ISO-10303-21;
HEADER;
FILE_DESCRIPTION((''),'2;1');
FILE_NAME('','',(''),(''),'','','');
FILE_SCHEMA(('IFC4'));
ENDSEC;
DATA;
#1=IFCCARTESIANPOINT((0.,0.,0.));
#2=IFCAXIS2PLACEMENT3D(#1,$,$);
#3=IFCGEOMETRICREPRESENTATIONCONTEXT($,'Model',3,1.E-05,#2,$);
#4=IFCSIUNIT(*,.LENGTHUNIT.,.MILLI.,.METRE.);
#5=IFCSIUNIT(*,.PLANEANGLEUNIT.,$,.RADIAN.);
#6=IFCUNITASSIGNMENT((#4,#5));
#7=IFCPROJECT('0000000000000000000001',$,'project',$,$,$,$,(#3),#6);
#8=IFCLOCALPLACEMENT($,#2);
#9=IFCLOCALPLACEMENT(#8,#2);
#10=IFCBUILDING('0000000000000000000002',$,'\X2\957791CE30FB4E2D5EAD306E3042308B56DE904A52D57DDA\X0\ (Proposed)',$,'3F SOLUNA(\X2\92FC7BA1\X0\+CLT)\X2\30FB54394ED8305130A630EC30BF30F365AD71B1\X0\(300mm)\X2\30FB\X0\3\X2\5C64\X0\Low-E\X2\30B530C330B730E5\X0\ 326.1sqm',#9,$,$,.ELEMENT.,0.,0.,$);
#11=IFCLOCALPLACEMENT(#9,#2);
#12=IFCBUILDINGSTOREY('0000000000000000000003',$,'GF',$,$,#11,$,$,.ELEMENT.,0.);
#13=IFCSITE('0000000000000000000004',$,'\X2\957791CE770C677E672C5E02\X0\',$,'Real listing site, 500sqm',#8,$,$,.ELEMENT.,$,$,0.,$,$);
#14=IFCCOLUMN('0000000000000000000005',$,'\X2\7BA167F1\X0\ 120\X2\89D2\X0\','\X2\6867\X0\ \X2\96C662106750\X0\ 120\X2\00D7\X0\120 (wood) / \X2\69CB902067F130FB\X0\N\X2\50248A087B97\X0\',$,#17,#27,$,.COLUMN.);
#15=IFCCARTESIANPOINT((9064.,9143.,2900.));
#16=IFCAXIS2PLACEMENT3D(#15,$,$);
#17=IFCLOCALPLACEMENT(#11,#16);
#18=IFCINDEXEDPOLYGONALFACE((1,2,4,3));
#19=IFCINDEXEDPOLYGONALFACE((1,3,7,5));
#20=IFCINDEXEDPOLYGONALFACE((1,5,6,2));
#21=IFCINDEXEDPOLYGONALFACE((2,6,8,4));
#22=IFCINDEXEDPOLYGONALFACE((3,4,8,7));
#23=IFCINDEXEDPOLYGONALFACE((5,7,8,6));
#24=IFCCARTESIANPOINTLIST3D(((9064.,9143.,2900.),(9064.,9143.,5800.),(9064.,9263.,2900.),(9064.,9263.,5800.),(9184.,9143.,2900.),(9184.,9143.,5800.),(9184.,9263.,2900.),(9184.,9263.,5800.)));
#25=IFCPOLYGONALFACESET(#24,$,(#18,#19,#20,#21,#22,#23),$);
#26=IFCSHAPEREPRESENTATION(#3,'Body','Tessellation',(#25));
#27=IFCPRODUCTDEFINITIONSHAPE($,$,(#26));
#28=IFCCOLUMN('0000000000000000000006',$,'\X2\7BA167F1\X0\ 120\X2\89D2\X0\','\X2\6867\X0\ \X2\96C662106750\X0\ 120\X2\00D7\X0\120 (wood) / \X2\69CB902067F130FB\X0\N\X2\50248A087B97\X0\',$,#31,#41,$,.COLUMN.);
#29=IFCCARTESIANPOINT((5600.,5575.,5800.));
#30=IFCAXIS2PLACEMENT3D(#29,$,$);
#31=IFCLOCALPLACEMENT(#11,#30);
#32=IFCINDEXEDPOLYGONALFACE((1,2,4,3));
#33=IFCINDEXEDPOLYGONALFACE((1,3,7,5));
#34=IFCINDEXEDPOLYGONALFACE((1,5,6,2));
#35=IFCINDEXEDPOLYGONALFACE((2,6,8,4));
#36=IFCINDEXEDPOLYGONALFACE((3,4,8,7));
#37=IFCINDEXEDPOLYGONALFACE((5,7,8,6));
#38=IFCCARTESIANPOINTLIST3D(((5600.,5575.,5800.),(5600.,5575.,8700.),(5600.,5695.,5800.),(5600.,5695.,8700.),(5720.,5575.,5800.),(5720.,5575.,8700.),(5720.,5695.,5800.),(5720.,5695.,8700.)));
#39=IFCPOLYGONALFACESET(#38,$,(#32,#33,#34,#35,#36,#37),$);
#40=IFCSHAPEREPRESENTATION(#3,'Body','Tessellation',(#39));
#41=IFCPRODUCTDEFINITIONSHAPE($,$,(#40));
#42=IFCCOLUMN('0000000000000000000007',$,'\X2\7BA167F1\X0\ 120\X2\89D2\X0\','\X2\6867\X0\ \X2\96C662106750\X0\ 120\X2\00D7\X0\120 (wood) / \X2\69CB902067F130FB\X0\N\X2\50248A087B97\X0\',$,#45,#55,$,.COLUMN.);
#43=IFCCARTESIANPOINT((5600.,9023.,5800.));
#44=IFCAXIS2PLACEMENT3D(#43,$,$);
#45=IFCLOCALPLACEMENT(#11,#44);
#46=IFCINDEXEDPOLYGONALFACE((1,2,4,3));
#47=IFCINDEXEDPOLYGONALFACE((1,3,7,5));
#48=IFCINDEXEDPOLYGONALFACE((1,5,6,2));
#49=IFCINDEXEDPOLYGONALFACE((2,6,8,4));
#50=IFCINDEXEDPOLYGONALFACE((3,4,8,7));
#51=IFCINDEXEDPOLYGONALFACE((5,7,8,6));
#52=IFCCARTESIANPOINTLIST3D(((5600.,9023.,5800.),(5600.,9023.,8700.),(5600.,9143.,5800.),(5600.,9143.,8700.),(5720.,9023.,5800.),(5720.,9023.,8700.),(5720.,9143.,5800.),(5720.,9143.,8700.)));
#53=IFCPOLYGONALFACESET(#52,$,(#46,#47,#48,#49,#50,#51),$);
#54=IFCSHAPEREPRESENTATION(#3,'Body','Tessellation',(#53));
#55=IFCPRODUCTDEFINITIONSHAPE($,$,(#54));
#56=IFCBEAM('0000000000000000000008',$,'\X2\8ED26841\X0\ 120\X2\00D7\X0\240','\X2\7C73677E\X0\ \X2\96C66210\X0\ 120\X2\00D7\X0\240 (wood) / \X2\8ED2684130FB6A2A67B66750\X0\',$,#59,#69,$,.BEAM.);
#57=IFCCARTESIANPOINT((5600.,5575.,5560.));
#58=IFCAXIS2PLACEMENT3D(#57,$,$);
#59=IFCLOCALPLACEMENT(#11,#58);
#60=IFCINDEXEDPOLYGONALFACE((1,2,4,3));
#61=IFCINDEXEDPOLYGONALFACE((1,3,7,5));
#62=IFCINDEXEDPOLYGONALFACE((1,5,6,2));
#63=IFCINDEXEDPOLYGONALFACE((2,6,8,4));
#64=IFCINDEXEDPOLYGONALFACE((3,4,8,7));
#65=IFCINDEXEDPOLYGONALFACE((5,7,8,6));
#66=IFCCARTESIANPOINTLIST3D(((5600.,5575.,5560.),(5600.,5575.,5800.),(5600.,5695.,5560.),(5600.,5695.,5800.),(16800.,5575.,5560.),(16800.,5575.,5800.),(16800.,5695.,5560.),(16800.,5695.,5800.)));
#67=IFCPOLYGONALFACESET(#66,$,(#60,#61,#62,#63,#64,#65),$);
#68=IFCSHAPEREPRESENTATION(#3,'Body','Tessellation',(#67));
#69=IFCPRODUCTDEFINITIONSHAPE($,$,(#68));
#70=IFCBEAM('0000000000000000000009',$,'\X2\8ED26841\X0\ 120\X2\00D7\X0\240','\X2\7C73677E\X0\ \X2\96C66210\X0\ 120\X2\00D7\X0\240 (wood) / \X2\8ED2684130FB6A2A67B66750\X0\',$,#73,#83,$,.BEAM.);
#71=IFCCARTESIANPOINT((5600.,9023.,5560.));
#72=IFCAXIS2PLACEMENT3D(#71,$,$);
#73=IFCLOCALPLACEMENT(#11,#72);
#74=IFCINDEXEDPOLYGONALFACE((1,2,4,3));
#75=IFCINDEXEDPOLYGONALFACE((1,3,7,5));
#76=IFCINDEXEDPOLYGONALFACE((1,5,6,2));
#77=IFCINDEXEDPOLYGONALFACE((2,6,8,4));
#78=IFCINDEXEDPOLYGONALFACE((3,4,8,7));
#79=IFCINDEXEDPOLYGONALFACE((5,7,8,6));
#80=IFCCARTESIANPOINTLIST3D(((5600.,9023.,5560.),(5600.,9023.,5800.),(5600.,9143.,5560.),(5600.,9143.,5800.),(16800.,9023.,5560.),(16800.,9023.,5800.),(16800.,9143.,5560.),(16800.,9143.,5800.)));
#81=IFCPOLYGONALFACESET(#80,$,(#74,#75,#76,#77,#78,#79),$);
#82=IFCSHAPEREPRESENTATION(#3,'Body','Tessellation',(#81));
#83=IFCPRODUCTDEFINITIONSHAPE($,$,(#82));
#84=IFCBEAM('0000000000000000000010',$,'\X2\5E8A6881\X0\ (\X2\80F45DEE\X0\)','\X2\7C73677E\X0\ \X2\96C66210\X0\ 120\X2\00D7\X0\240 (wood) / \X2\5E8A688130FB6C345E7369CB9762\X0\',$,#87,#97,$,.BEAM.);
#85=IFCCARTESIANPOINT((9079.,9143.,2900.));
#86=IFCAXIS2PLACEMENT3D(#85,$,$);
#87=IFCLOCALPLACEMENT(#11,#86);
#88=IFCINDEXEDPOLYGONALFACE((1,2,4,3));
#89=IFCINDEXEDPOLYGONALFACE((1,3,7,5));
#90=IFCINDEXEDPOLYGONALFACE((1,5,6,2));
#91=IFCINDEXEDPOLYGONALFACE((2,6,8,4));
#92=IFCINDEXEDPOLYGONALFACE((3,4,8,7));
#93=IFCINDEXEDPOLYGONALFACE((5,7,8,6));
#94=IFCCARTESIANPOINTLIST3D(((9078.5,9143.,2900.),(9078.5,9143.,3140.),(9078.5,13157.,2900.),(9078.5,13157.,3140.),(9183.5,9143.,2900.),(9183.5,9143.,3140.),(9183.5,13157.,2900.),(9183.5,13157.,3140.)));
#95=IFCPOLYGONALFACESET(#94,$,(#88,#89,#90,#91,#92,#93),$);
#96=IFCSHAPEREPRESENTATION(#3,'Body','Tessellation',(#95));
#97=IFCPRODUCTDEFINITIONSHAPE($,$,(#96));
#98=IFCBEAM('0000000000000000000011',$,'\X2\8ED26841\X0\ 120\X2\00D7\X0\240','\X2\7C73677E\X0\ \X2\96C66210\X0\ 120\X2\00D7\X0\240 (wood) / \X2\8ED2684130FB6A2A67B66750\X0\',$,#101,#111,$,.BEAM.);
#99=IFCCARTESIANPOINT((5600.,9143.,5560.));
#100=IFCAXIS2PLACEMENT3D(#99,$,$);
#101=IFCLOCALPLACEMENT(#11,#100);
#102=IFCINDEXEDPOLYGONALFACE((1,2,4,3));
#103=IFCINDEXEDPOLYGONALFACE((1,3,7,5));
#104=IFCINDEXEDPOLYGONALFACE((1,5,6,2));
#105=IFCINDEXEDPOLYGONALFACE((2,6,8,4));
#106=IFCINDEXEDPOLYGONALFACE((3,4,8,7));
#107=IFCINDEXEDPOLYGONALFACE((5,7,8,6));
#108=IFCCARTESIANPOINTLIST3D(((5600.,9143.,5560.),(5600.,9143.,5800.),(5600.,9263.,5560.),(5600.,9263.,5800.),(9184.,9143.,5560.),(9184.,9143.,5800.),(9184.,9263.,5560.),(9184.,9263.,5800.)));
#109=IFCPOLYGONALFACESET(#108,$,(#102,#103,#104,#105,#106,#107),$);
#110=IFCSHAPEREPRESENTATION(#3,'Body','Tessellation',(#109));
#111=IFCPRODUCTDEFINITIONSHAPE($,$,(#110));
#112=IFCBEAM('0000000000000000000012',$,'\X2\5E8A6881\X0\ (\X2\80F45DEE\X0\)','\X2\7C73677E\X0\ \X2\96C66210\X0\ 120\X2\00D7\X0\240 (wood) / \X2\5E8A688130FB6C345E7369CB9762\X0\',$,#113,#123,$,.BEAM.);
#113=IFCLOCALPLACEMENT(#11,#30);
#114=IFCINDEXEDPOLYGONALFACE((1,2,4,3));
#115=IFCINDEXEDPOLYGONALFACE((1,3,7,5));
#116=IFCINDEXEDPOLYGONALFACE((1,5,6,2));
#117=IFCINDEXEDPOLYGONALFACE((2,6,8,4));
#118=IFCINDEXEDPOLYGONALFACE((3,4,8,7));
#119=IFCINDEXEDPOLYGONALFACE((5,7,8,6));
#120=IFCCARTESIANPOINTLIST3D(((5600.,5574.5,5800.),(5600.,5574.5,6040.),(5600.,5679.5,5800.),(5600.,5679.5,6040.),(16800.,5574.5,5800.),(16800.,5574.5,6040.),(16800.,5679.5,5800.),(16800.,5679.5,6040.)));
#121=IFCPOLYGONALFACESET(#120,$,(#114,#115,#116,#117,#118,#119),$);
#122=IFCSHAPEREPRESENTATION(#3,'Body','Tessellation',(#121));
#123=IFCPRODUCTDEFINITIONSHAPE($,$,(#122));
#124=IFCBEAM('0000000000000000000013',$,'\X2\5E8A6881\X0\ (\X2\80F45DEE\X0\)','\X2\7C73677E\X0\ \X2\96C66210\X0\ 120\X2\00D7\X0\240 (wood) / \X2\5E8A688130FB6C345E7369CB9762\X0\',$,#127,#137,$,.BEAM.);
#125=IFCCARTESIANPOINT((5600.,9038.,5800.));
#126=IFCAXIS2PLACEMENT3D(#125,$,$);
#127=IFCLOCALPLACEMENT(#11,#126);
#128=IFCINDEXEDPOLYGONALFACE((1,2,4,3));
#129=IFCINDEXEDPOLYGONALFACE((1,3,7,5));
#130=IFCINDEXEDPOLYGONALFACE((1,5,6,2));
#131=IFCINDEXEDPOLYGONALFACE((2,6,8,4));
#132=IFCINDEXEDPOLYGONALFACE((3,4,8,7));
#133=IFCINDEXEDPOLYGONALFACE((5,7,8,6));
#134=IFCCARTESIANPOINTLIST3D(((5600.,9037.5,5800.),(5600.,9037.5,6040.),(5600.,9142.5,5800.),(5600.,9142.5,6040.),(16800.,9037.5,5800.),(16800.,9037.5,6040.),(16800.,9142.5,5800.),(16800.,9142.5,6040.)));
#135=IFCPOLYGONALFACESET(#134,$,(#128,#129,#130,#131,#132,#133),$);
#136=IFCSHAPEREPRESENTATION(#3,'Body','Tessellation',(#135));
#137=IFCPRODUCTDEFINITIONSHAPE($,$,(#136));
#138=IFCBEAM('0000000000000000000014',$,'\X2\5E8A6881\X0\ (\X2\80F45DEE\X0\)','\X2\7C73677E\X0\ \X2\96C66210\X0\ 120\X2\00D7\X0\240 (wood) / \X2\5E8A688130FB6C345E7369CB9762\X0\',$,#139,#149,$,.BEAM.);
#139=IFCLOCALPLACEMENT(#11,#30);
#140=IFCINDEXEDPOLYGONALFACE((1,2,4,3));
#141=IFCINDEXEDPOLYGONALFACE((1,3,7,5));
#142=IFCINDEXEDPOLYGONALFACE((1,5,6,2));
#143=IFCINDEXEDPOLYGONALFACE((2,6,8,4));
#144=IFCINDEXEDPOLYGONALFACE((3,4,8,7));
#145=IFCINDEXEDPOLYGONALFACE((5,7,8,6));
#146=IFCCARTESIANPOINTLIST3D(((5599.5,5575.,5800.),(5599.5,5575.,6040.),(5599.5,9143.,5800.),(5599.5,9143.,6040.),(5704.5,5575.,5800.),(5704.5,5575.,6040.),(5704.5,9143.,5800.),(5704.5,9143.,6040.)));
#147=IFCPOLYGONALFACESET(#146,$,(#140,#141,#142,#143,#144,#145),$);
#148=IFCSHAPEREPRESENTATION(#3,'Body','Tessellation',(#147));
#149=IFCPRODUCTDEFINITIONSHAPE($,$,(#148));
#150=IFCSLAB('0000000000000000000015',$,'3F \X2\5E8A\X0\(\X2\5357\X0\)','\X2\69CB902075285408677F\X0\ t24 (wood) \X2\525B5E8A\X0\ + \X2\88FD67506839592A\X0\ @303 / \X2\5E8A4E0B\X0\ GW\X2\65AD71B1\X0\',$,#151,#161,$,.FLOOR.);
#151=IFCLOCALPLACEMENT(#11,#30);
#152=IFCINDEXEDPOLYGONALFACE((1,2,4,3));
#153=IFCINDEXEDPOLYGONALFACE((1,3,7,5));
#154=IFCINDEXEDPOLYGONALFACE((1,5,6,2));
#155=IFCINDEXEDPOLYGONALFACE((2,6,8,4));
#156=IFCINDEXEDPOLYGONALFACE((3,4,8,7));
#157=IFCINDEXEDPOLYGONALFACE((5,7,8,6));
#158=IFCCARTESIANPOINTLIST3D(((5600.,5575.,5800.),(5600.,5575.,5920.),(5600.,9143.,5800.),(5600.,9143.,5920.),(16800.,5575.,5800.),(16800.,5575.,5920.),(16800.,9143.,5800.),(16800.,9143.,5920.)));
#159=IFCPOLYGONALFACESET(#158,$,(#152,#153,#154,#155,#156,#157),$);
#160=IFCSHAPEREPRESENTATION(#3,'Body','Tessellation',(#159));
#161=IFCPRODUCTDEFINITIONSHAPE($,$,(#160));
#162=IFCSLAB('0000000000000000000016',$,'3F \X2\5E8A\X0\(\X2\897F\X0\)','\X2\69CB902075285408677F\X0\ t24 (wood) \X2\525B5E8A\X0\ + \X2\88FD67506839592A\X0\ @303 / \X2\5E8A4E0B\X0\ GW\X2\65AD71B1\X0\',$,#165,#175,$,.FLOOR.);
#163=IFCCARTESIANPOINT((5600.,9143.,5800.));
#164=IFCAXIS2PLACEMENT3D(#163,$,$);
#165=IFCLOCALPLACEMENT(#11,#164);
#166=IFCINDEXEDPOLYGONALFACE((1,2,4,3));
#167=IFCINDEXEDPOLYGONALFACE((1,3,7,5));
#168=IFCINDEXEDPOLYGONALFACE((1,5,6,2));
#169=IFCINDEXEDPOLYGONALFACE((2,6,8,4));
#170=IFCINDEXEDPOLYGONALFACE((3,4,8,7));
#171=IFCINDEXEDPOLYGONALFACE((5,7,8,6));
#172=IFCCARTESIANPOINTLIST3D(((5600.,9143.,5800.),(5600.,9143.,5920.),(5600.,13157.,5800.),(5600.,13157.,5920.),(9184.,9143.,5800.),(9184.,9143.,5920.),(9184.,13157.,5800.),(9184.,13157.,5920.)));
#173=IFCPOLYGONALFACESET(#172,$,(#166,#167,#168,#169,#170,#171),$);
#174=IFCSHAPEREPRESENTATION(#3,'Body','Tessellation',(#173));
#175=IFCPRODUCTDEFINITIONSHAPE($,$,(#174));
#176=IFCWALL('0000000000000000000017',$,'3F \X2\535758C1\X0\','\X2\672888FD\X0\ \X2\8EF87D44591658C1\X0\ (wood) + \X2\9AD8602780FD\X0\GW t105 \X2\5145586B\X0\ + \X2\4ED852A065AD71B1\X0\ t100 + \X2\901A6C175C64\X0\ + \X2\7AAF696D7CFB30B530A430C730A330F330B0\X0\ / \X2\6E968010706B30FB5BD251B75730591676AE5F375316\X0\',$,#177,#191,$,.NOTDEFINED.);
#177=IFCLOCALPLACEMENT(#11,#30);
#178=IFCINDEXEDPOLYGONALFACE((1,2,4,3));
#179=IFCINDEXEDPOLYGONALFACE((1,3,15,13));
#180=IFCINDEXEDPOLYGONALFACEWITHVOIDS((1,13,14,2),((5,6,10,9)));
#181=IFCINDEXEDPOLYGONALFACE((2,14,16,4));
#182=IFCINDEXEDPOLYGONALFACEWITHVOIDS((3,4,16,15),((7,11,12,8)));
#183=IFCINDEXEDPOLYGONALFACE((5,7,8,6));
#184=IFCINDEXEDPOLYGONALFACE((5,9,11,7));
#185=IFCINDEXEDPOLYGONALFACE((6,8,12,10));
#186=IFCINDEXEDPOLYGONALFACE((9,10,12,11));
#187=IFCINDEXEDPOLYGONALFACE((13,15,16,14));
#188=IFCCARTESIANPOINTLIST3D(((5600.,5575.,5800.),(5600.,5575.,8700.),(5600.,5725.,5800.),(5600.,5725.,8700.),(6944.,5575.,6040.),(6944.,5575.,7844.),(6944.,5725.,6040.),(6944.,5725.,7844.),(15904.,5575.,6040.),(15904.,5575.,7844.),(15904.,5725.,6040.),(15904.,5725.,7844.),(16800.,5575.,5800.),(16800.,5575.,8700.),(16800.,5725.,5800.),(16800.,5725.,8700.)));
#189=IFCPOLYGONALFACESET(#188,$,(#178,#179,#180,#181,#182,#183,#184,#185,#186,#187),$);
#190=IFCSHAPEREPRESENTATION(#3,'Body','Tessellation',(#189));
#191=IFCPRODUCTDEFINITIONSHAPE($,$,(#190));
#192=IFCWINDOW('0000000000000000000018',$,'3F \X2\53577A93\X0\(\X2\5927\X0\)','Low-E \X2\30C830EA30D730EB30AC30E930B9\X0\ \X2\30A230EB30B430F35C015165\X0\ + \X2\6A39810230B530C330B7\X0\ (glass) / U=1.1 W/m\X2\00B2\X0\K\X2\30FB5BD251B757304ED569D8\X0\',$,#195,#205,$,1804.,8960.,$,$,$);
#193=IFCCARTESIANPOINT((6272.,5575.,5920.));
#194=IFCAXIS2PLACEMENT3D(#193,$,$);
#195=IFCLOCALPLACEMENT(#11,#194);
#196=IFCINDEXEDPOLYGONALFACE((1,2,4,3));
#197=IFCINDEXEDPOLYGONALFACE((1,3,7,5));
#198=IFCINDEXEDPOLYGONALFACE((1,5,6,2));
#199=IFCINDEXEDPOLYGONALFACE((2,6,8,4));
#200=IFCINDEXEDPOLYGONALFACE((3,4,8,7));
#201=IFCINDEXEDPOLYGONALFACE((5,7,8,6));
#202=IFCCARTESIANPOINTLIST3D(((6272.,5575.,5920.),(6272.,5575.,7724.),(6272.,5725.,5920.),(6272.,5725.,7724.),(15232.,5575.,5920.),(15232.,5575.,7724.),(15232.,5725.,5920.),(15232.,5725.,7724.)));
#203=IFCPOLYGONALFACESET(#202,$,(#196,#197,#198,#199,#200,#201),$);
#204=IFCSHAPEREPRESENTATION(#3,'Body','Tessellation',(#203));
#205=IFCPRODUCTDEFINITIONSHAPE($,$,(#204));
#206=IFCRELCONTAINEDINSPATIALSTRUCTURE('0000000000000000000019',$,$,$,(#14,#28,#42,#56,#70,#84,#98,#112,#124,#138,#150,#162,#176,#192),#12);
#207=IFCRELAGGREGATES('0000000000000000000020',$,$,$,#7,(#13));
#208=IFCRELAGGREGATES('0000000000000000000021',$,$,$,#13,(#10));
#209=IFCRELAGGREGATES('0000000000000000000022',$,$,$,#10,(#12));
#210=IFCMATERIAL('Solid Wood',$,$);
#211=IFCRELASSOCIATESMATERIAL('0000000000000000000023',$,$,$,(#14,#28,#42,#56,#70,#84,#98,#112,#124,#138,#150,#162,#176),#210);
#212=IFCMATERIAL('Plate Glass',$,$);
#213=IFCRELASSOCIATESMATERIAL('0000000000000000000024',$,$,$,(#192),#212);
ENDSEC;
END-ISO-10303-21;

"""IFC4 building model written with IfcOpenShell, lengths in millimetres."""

from ifc_helpers import new_model, si_unit, frame, frame_2d, origin, place, context, project, spatial, rectangle, extrude, material, element, fill, save


model = new_model("IFC4")

# Units and contexts
model_context = context("Model", 3, precision=1e-05, world=origin())
ifc_project = project(units=[si_unit("LENGTHUNIT", "METRE", prefix="MILLI"), si_unit("PLANEANGLEUNIT", "RADIAN")], contexts=[model_context])

# Site, building, storey
site_placement = place(None, origin())
site = spatial("IfcSite", under=ifc_project, at=site_placement, Name="長野県松本市", ObjectType="Real listing site, 500sqm", CompositionType="ELEMENT", RefElevation=0.0)
building_placement = place(site_placement, origin())
building = spatial("IfcBuilding", under=site, at=building_placement, Name="長野・中庭のある回遊動線 (Proposed)", ObjectType="3F SOLUNA(鋼管+CLT)・吹付けウレタン断熱(300mm)・3層Low-Eサッシュ 326.1sqm", CompositionType="ELEMENT", ElevationOfRefHeight=0.0, ElevationOfTerrain=0.0)
storey_placement = place(building_placement, origin())
storey = spatial("IfcBuildingStorey", under=building, at=storey_placement, Name="GF", CompositionType="ELEMENT", Elevation=0.0)

# Columns
ifc_material_1 = material(Name="Solid Wood")
column_1_placement = place(storey_placement, frame((9064.0, 9143.0, 2900.0)))
element("IfcColumn", 1, at=column_1_placement, inside=storey, material=ifc_material_1, Name="管柱 120角", Description="桧 集成材 120×120 (wood) / 構造柱・N値計算", PredefinedType="COLUMN", context=model_context, shape_type="SweptSolid", body=[
    extrude(rectangle(XDim=120.0, YDim=120.0, at=frame_2d((60.0, 60.0))), frame((9064.0, 9143.0, 2900.0)), (0.0, 0.0, 1.0), 2900.0),
])
column_2_placement = place(storey_placement, frame((5600.0, 5575.0, 5800.0)))
element("IfcColumn", 2, at=column_2_placement, inside=storey, material=ifc_material_1, Name="管柱 120角", Description="桧 集成材 120×120 (wood) / 構造柱・N値計算", PredefinedType="COLUMN", context=model_context, shape_type="SweptSolid", body=[
    extrude(rectangle(XDim=120.0, YDim=120.0, at=frame_2d((60.0, 60.0))), frame((5600.0, 5575.0, 5800.0)), (0.0, 0.0, 1.0), 2900.0),
])
column_3_placement = place(storey_placement, frame((5600.0, 9023.0, 5800.0)))
element("IfcColumn", 3, at=column_3_placement, inside=storey, material=ifc_material_1, Name="管柱 120角", Description="桧 集成材 120×120 (wood) / 構造柱・N値計算", PredefinedType="COLUMN", context=model_context, shape_type="SweptSolid", body=[
    extrude(rectangle(XDim=120.0, YDim=120.0, at=frame_2d((60.0, 60.0))), frame((5600.0, 9023.0, 5800.0)), (0.0, 0.0, 1.0), 2900.0),
])

# Beams
beam_1_placement = place(storey_placement, frame((5600.0, 5575.0, 5560.0)))
element("IfcBeam", 4, at=beam_1_placement, inside=storey, material=ifc_material_1, Name="軒桁 120×240", Description="米松 集成 120×240 (wood) / 軒桁・横架材", PredefinedType="BEAM", context=model_context, shape_type="SweptSolid", body=[
    extrude(rectangle(XDim=11200.0, YDim=120.0, at=frame_2d((5600.0, 60.0))), frame((5600.0, 5575.0, 5560.0)), (0.0, 0.0, 1.0), 240.0),
])
beam_2_placement = place(storey_placement, frame((5600.0, 9023.0, 5560.0)))
element("IfcBeam", 5, at=beam_2_placement, inside=storey, material=ifc_material_1, Name="軒桁 120×240", Description="米松 集成 120×240 (wood) / 軒桁・横架材", PredefinedType="BEAM", context=model_context, shape_type="SweptSolid", body=[
    extrude(rectangle(XDim=11200.0, YDim=120.0, at=frame_2d((5600.0, 60.0))), frame((5600.0, 9023.0, 5560.0)), (0.0, 0.0, 1.0), 240.0),
])
beam_3_placement = place(storey_placement, frame((9079.0, 9143.0, 2900.0)))
element("IfcBeam", 6, at=beam_3_placement, inside=storey, material=ifc_material_1, Name="床梁 (胴差)", Description="米松 集成 120×240 (wood) / 床梁・水平構面", PredefinedType="BEAM", context=model_context, shape_type="SweptSolid", body=[
    extrude(rectangle(XDim=105.0, YDim=4014.0, at=frame_2d((52.0, 2007.0))), frame((9079.0, 9143.0, 2900.0)), (0.0, 0.0, 1.0), 240.0),
])
beam_4_placement = place(storey_placement, frame((5600.0, 9143.0, 5560.0)))
element("IfcBeam", 7, at=beam_4_placement, inside=storey, material=ifc_material_1, Name="軒桁 120×240", Description="米松 集成 120×240 (wood) / 軒桁・横架材", PredefinedType="BEAM", context=model_context, shape_type="SweptSolid", body=[
    extrude(rectangle(XDim=3584.0, YDim=120.0, at=frame_2d((1792.0, 60.0))), frame((5600.0, 9143.0, 5560.0)), (0.0, 0.0, 1.0), 240.0),
])
beam_5_placement = place(storey_placement, frame((5600.0, 5575.0, 5800.0)))
element("IfcBeam", 8, at=beam_5_placement, inside=storey, material=ifc_material_1, Name="床梁 (胴差)", Description="米松 集成 120×240 (wood) / 床梁・水平構面", PredefinedType="BEAM", context=model_context, shape_type="SweptSolid", body=[
    extrude(rectangle(XDim=11200.0, YDim=105.0, at=frame_2d((5600.0, 52.0))), frame((5600.0, 5575.0, 5800.0)), (0.0, 0.0, 1.0), 240.0),
])
beam_6_placement = place(storey_placement, frame((5600.0, 9038.0, 5800.0)))
element("IfcBeam", 9, at=beam_6_placement, inside=storey, material=ifc_material_1, Name="床梁 (胴差)", Description="米松 集成 120×240 (wood) / 床梁・水平構面", PredefinedType="BEAM", context=model_context, shape_type="SweptSolid", body=[
    extrude(rectangle(XDim=11200.0, YDim=105.0, at=frame_2d((5600.0, 52.0))), frame((5600.0, 9038.0, 5800.0)), (0.0, 0.0, 1.0), 240.0),
])
beam_7_placement = place(storey_placement, frame((5600.0, 5575.0, 5800.0)))
element("IfcBeam", 10, at=beam_7_placement, inside=storey, material=ifc_material_1, Name="床梁 (胴差)", Description="米松 集成 120×240 (wood) / 床梁・水平構面", PredefinedType="BEAM", context=model_context, shape_type="SweptSolid", body=[
    extrude(rectangle(XDim=105.0, YDim=3568.0, at=frame_2d((52.0, 1784.0))), frame((5600.0, 5575.0, 5800.0)), (0.0, 0.0, 1.0), 240.0),
])

# Slabs
slab_1_placement = place(storey_placement, frame((5600.0, 5575.0, 5800.0)))
element("IfcSlab", 11, at=slab_1_placement, inside=storey, material=ifc_material_1, Name="3F 床(南)", Description="構造用合板 t24 (wood) 剛床 + 製材根太 @303 / 床下 GW断熱", PredefinedType="FLOOR", context=model_context, shape_type="SweptSolid", body=[
    extrude(rectangle(XDim=11200.0, YDim=3568.0, at=frame_2d((5600.0, 1784.0))), frame((5600.0, 5575.0, 5800.0)), (0.0, 0.0, 1.0), 120.0),
])
slab_2_placement = place(storey_placement, frame((5600.0, 9143.0, 5800.0)))
element("IfcSlab", 12, at=slab_2_placement, inside=storey, material=ifc_material_1, Name="3F 床(西)", Description="構造用合板 t24 (wood) 剛床 + 製材根太 @303 / 床下 GW断熱", PredefinedType="FLOOR", context=model_context, shape_type="SweptSolid", body=[
    extrude(rectangle(XDim=3584.0, YDim=4014.0, at=frame_2d((1792.0, 2007.0))), frame((5600.0, 9143.0, 5800.0)), (0.0, 0.0, 1.0), 120.0),
])

# Wall, opening, window
wall_1_placement = place(storey_placement, frame((5600.0, 5575.0, 5800.0)))
wall_1 = element("IfcWall", 13, at=wall_1_placement, inside=storey, material=ifc_material_1, Name="3F 南壁", Description="木製 軸組外壁 (wood) + 高性能GW t105 充填 + 付加断熱 t100 + 通気層 + 窯業系サイディング / 準耐火・寒冷地外皮強化", PredefinedType="NOTDEFINED", context=model_context, shape_type="SweptSolid", body=[
    extrude(rectangle(XDim=11200.0, YDim=150.0, at=frame_2d((5600.0, 75.0))), frame((5600.0, 5575.0, 5800.0)), (0.0, 0.0, 1.0), 2900.0),
])
opening_1_placement = place(storey_placement, frame((6272.0, 5575.0, 5920.0)))
opening_1 = element("IfcOpeningElement", 14, at=opening_1_placement, cuts=wall_1, PredefinedType="NOTDEFINED", context=model_context, shape_type="SweptSolid", body=[
    extrude(rectangle(XDim=8960.0, YDim=150.0, at=frame_2d((4480.0, 75.0))), frame((6272.0, 5575.0, 5920.0)), (0.0, 0.0, 1.0), 1804.0),
])
ifc_material_2 = material(Name="Plate Glass")
window_1_placement = place(storey_placement, frame((6272.0, 5575.0, 5920.0)))
window_1 = element("IfcWindow", 15, at=window_1_placement, inside=storey, material=ifc_material_2, Name="3F 南窓(大)", Description="Low-E トリプルガラス アルゴン封入 + 樹脂サッシ (glass) / U=1.1 W/m²K・寒冷地仕様", OverallHeight=1804.0, OverallWidth=8960.0, context=model_context, shape_type="SweptSolid", body=[
    extrude(rectangle(XDim=8960.0, YDim=150.0, at=frame_2d((4480.0, 75.0))), frame((6272.0, 5575.0, 5920.0)), (0.0, 0.0, 1.0), 1804.0),
])
fill(opening_1, window_1)

save(model, "model.ifc")
